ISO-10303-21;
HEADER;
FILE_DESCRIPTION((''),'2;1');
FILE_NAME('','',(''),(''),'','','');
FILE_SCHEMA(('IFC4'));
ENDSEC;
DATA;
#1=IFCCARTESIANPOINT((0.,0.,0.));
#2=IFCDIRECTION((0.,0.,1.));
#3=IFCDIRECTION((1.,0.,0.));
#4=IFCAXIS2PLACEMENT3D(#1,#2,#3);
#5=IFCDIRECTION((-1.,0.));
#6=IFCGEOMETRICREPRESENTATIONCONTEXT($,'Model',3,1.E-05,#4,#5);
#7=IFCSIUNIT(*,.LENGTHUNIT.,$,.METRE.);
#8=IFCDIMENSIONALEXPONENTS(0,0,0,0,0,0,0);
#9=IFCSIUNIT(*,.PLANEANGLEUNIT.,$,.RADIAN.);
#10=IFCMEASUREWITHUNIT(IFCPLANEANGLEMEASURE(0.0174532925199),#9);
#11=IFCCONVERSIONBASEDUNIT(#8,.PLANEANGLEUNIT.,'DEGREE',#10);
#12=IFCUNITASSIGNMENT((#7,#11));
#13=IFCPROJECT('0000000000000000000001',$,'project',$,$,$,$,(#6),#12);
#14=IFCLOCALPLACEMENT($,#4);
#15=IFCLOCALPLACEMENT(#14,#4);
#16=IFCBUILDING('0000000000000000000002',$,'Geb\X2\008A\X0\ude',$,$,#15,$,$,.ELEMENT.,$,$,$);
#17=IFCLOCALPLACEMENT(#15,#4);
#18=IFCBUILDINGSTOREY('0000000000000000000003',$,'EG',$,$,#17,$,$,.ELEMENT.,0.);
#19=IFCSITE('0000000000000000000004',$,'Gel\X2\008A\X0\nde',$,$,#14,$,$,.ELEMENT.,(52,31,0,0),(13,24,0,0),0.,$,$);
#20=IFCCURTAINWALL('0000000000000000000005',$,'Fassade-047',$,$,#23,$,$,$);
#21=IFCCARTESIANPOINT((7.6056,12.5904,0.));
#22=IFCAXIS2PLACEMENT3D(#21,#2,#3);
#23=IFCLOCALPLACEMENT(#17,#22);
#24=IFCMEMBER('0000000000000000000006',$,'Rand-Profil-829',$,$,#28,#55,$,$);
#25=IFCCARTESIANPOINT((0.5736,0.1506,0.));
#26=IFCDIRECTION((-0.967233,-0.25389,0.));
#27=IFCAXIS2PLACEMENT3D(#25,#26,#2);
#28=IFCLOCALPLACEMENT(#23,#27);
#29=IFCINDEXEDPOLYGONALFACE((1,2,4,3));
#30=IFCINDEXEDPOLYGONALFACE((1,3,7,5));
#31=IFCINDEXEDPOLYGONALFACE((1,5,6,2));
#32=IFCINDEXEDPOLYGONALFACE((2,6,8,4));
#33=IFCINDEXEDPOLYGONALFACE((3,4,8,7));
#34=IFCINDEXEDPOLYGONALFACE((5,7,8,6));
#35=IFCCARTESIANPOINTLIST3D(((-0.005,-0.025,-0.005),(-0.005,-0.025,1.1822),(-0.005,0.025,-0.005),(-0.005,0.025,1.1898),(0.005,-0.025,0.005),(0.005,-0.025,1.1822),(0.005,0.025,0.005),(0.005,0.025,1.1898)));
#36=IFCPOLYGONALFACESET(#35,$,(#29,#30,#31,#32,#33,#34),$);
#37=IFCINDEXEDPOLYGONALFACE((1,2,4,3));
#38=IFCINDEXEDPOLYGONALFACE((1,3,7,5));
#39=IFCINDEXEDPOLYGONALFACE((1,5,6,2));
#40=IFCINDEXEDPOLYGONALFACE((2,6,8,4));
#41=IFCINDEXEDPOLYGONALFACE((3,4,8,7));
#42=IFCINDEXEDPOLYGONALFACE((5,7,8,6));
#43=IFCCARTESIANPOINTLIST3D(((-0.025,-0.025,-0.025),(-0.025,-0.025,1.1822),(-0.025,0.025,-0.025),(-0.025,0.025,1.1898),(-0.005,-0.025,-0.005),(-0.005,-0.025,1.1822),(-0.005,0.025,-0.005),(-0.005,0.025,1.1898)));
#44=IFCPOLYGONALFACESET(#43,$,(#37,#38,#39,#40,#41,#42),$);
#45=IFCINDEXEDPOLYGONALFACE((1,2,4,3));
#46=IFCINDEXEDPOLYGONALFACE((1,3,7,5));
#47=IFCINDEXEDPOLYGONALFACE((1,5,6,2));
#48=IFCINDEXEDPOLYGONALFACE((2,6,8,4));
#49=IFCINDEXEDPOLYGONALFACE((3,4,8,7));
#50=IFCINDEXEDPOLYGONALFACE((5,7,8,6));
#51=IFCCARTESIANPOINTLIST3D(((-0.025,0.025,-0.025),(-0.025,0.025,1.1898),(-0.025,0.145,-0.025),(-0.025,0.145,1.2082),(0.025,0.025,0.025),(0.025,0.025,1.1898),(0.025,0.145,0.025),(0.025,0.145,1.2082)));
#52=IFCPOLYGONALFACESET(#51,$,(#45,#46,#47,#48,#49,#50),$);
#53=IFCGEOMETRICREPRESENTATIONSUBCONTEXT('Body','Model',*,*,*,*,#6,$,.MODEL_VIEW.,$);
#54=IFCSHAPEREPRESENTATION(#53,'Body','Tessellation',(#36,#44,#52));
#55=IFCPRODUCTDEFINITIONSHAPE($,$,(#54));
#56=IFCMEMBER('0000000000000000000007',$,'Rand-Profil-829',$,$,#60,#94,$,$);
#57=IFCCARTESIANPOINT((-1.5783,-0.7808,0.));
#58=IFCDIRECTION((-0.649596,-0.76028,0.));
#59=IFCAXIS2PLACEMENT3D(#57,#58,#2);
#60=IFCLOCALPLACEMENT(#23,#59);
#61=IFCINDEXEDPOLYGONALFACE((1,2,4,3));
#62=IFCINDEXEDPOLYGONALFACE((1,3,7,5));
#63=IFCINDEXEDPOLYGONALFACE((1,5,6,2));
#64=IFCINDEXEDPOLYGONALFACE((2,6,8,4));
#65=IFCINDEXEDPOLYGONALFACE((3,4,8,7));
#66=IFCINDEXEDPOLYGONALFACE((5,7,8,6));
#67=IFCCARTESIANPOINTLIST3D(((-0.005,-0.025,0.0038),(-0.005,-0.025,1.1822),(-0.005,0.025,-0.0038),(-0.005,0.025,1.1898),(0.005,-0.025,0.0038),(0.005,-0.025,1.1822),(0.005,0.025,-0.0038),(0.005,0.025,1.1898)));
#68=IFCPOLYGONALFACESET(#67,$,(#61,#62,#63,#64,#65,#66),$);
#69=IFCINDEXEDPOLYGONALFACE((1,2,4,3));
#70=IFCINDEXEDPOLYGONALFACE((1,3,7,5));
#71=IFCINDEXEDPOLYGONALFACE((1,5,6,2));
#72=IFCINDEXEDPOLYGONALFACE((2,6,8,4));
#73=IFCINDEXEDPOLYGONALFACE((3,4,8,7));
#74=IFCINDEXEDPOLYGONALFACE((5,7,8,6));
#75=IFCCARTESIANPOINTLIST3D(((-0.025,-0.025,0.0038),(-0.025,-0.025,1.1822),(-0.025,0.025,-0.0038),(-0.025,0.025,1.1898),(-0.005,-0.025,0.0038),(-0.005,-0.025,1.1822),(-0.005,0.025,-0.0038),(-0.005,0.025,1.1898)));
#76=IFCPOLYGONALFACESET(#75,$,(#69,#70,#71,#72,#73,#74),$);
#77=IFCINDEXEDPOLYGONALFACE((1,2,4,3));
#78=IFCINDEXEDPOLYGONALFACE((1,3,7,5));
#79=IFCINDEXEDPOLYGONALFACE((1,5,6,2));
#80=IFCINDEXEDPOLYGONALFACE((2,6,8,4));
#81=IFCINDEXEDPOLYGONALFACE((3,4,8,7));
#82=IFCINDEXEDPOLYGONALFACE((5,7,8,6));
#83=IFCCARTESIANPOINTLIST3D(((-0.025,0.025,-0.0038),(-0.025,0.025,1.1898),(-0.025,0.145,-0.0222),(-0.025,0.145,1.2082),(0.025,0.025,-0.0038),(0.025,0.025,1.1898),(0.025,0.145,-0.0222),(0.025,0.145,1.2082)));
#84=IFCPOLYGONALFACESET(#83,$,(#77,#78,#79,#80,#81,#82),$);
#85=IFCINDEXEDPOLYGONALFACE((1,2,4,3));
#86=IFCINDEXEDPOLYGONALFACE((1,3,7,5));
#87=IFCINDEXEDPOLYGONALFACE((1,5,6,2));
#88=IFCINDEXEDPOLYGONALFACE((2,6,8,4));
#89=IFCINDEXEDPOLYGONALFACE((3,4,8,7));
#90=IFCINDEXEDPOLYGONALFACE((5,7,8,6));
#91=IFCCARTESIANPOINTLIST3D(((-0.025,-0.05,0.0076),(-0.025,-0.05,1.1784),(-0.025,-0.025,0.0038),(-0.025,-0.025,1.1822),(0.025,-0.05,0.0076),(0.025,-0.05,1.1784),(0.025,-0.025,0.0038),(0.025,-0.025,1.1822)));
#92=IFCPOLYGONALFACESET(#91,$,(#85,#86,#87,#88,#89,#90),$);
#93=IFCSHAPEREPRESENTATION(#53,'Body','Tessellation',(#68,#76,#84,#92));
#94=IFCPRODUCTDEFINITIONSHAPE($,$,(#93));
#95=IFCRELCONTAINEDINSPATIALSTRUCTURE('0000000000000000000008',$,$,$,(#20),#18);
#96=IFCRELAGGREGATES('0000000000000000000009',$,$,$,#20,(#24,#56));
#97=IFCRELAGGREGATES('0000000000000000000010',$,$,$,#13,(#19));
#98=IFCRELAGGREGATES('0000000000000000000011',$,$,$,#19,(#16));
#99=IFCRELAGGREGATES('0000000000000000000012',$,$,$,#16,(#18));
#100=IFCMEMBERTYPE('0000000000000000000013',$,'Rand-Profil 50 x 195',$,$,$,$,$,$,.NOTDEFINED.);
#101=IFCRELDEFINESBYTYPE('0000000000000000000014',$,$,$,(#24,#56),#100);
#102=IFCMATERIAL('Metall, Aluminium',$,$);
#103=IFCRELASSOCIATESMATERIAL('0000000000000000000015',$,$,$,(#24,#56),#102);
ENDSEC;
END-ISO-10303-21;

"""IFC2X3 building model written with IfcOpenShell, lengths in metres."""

from ifc_helpers import new_model, entity, si_unit, converted_unit, direction, frame, origin_with_axes, place, context, subcontext, project, spatial, polyline, outline, extrude, clip, halfspace, material, type_object, element, aggregate, save


model = new_model("IFC2X3")

# Units and contexts
model_context = context("Model", 3, precision=1e-05, world=origin_with_axes(), true_north=direction((-1.0, 0.0)))
body_context = subcontext(model_context, "Body", "Model", "MODEL_VIEW")
ifc_project = project(units=[si_unit("LENGTHUNIT", "METRE"), converted_unit("PLANEANGLEUNIT", "DEGREE", entity("IfcPlaneAngleMeasure", 0.0174532925199), si_unit("PLANEANGLEUNIT", "RADIAN"), dimensions=[0, 0, 0, 0, 0, 0, 0])], contexts=[model_context])

# Site, building, storey
site_placement = place(None, origin_with_axes())
site = spatial("IfcSite", under=ifc_project, at=site_placement, Name="Gel\u008ande", CompositionType="ELEMENT", RefLatitude=(52, 31, 0, 0), RefLongitude=(13, 24, 0, 0), RefElevation=0.0)
building_placement = place(site_placement, origin_with_axes())
building = spatial("IfcBuilding", under=site, at=building_placement, Name="Geb\u008aude", CompositionType="ELEMENT")
storey_placement = place(building_placement, origin_with_axes())
storey = spatial("IfcBuildingStorey", under=building, at=storey_placement, Name="EG", CompositionType="ELEMENT", Elevation=0.0)

# Curtain wall
curtain_wall_1_placement = place(storey_placement, frame((7.6056, 12.5904, 0.0), z_axis=(0.0, 0.0, 1.0), x_axis=(1.0, 0.0, 0.0)))
curtain_wall_1 = element("IfcCurtainWall", 1, at=curtain_wall_1_placement, inside=storey, Name="Fassade-047")
ifc_material_1 = material(Name="Metall, Aluminium")

# Members
member_type_1 = type_object("IfcMemberType", Name="Rand-Profil 50 x 195", PredefinedType="NOTDEFINED")
member_1_placement = place(curtain_wall_1_placement, frame((0.5736, 0.1506, 0.0), z_axis=(-0.967233, -0.25389, 0.0), x_axis=(0.0, 0.0, 1.0)))
member_1 = element("IfcMember", 2, at=member_1_placement, type_object=member_type_1, material=ifc_material_1, Name="Rand-Profil-829", context=body_context, shape_type="Clipping", body=[
    clip(clip(extrude(outline(polyline([(0.025, -0.005), (0.025, 0.005), (-0.025, 0.005), (-0.025, -0.005), (0.025, -0.005)])), frame((0.0, 0.0, -0.005), z_axis=(0.0, 0.0, 1.0), x_axis=(0.0, 1.0, 0.0)), (0.0, 0.0, 1.0), 1.1948), halfspace(frame((0.0, -0.1772, 1.1589), z_axis=(0.0, 0.151179, -0.988506), x_axis=(0.0, -0.988506, -0.151179)), True)), halfspace(frame((0.0, 0.0, 0.0), z_axis=(-0.707107, 0.0, 0.707107), x_axis=(-0.707107, 0.0, -0.707107)), True)),
    clip(clip(extrude(outline(polyline([(0.025, 0.005), (0.025, 0.025), (-0.025, 0.025), (-0.025, 0.005), (0.025, 0.005)])), frame((0.0, 0.0, -0.025), z_axis=(0.0, 0.0, 1.0), x_axis=(0.0, 1.0, 0.0)), (0.0, 0.0, 1.0), 1.2148), halfspace(frame((0.0, -0.1772, 1.1589), z_axis=(0.0, 0.151179, -0.988506), x_axis=(0.0, -0.988506, -0.151179)), True)), halfspace(frame((0.0, 0.0, 0.0), z_axis=(-0.707107, 0.0, 0.707107), x_axis=(-0.707107, 0.0, -0.707107)), True)),
    clip(clip(extrude(outline(polyline([(0.145, -0.025), (0.145, 0.025), (0.025, 0.025), (0.025, -0.025), (0.145, -0.025)])), frame((0.0, 0.0, -0.025), z_axis=(0.0, 0.0, 1.0), x_axis=(0.0, 1.0, 0.0)), (0.0, 0.0, 1.0), 1.2332), halfspace(frame((0.0, -0.1772, 1.1589), z_axis=(0.0, 0.151179, -0.988506), x_axis=(0.0, -0.988506, -0.151179)), True)), halfspace(frame((0.0, 0.0, 0.0), z_axis=(-0.707107, 0.0, 0.707107), x_axis=(-0.707107, 0.0, -0.707107)), True)),
])
member_2_placement = place(curtain_wall_1_placement, frame((-1.5783, -0.7808, 0.0), z_axis=(-0.649596, -0.76028, 0.0), x_axis=(0.0, 0.0, 1.0)))
member_2 = element("IfcMember", 3, at=member_2_placement, type_object=member_type_1, material=ifc_material_1, Name="Rand-Profil-829", context=body_context, shape_type="Clipping", body=[
    clip(clip(extrude(outline(polyline([(0.025, -0.005), (0.025, 0.005), (-0.025, 0.005), (-0.025, -0.005), (0.025, -0.005)])), frame((0.0, 0.0, -0.0038), z_axis=(0.0, 0.0, 1.0), x_axis=(0.0, 1.0, 0.0)), (0.0, 0.0, 1.0), 1.1936), halfspace(frame((0.0, -0.1772, 1.1589), z_axis=(0.0, 0.151179, -0.988506), x_axis=(0.0, -0.988506, -0.151179)), True)), halfspace(frame((0.0, 0.0, 0.0), z_axis=(0.0, 0.151179, 0.988506), x_axis=(0.0, 0.988506, -0.151179)), True)),
    clip(clip(extrude(outline(polyline([(0.025, 0.005), (0.025, 0.025), (-0.025, 0.025), (-0.025, 0.005), (0.025, 0.005)])), frame((0.0, 0.0, -0.0038), z_axis=(0.0, 0.0, 1.0), x_axis=(0.0, 1.0, 0.0)), (0.0, 0.0, 1.0), 1.1936), halfspace(frame((0.0, -0.1772, 1.1589), z_axis=(0.0, 0.151179, -0.988506), x_axis=(0.0, -0.988506, -0.151179)), True)), halfspace(frame((0.0, 0.0, 0.0), z_axis=(0.0, 0.151179, 0.988506), x_axis=(0.0, 0.988506, -0.151179)), True)),
    clip(clip(extrude(outline(polyline([(0.145, -0.025), (0.145, 0.025), (0.025, 0.025), (0.025, -0.025), (0.145, -0.025)])), frame((0.0, 0.0, -0.0222), z_axis=(0.0, 0.0, 1.0), x_axis=(0.0, 1.0, 0.0)), (0.0, 0.0, 1.0), 1.2304), halfspace(frame((0.0, -0.1772, 1.1589), z_axis=(0.0, 0.151179, -0.988506), x_axis=(0.0, -0.988506, -0.151179)), True)), halfspace(frame((0.0, 0.0, 0.0), z_axis=(0.0, 0.151179, 0.988506), x_axis=(0.0, 0.988506, -0.151179)), True)),
    clip(clip(extrude(outline(polyline([(-0.05, 0.025), (-0.05, -0.025), (-0.025, -0.025), (-0.025, 0.025), (-0.05, 0.025)])), frame((0.0, 0.0, 0.0038), z_axis=(0.0, 0.0, 1.0), x_axis=(0.0, 1.0, 0.0)), (0.0, 0.0, 1.0), 1.1784), halfspace(frame((0.0, -0.1772, 1.1589), z_axis=(0.0, 0.151179, -0.988506), x_axis=(0.0, -0.988506, -0.151179)), True)), halfspace(frame((0.0, 0.0, 0.0), z_axis=(0.0, 0.151179, 0.988506), x_axis=(0.0, 0.988506, -0.151179)), True)),
])

aggregate(curtain_wall_1, [member_1, member_2])

save(model, "model.ifc")
